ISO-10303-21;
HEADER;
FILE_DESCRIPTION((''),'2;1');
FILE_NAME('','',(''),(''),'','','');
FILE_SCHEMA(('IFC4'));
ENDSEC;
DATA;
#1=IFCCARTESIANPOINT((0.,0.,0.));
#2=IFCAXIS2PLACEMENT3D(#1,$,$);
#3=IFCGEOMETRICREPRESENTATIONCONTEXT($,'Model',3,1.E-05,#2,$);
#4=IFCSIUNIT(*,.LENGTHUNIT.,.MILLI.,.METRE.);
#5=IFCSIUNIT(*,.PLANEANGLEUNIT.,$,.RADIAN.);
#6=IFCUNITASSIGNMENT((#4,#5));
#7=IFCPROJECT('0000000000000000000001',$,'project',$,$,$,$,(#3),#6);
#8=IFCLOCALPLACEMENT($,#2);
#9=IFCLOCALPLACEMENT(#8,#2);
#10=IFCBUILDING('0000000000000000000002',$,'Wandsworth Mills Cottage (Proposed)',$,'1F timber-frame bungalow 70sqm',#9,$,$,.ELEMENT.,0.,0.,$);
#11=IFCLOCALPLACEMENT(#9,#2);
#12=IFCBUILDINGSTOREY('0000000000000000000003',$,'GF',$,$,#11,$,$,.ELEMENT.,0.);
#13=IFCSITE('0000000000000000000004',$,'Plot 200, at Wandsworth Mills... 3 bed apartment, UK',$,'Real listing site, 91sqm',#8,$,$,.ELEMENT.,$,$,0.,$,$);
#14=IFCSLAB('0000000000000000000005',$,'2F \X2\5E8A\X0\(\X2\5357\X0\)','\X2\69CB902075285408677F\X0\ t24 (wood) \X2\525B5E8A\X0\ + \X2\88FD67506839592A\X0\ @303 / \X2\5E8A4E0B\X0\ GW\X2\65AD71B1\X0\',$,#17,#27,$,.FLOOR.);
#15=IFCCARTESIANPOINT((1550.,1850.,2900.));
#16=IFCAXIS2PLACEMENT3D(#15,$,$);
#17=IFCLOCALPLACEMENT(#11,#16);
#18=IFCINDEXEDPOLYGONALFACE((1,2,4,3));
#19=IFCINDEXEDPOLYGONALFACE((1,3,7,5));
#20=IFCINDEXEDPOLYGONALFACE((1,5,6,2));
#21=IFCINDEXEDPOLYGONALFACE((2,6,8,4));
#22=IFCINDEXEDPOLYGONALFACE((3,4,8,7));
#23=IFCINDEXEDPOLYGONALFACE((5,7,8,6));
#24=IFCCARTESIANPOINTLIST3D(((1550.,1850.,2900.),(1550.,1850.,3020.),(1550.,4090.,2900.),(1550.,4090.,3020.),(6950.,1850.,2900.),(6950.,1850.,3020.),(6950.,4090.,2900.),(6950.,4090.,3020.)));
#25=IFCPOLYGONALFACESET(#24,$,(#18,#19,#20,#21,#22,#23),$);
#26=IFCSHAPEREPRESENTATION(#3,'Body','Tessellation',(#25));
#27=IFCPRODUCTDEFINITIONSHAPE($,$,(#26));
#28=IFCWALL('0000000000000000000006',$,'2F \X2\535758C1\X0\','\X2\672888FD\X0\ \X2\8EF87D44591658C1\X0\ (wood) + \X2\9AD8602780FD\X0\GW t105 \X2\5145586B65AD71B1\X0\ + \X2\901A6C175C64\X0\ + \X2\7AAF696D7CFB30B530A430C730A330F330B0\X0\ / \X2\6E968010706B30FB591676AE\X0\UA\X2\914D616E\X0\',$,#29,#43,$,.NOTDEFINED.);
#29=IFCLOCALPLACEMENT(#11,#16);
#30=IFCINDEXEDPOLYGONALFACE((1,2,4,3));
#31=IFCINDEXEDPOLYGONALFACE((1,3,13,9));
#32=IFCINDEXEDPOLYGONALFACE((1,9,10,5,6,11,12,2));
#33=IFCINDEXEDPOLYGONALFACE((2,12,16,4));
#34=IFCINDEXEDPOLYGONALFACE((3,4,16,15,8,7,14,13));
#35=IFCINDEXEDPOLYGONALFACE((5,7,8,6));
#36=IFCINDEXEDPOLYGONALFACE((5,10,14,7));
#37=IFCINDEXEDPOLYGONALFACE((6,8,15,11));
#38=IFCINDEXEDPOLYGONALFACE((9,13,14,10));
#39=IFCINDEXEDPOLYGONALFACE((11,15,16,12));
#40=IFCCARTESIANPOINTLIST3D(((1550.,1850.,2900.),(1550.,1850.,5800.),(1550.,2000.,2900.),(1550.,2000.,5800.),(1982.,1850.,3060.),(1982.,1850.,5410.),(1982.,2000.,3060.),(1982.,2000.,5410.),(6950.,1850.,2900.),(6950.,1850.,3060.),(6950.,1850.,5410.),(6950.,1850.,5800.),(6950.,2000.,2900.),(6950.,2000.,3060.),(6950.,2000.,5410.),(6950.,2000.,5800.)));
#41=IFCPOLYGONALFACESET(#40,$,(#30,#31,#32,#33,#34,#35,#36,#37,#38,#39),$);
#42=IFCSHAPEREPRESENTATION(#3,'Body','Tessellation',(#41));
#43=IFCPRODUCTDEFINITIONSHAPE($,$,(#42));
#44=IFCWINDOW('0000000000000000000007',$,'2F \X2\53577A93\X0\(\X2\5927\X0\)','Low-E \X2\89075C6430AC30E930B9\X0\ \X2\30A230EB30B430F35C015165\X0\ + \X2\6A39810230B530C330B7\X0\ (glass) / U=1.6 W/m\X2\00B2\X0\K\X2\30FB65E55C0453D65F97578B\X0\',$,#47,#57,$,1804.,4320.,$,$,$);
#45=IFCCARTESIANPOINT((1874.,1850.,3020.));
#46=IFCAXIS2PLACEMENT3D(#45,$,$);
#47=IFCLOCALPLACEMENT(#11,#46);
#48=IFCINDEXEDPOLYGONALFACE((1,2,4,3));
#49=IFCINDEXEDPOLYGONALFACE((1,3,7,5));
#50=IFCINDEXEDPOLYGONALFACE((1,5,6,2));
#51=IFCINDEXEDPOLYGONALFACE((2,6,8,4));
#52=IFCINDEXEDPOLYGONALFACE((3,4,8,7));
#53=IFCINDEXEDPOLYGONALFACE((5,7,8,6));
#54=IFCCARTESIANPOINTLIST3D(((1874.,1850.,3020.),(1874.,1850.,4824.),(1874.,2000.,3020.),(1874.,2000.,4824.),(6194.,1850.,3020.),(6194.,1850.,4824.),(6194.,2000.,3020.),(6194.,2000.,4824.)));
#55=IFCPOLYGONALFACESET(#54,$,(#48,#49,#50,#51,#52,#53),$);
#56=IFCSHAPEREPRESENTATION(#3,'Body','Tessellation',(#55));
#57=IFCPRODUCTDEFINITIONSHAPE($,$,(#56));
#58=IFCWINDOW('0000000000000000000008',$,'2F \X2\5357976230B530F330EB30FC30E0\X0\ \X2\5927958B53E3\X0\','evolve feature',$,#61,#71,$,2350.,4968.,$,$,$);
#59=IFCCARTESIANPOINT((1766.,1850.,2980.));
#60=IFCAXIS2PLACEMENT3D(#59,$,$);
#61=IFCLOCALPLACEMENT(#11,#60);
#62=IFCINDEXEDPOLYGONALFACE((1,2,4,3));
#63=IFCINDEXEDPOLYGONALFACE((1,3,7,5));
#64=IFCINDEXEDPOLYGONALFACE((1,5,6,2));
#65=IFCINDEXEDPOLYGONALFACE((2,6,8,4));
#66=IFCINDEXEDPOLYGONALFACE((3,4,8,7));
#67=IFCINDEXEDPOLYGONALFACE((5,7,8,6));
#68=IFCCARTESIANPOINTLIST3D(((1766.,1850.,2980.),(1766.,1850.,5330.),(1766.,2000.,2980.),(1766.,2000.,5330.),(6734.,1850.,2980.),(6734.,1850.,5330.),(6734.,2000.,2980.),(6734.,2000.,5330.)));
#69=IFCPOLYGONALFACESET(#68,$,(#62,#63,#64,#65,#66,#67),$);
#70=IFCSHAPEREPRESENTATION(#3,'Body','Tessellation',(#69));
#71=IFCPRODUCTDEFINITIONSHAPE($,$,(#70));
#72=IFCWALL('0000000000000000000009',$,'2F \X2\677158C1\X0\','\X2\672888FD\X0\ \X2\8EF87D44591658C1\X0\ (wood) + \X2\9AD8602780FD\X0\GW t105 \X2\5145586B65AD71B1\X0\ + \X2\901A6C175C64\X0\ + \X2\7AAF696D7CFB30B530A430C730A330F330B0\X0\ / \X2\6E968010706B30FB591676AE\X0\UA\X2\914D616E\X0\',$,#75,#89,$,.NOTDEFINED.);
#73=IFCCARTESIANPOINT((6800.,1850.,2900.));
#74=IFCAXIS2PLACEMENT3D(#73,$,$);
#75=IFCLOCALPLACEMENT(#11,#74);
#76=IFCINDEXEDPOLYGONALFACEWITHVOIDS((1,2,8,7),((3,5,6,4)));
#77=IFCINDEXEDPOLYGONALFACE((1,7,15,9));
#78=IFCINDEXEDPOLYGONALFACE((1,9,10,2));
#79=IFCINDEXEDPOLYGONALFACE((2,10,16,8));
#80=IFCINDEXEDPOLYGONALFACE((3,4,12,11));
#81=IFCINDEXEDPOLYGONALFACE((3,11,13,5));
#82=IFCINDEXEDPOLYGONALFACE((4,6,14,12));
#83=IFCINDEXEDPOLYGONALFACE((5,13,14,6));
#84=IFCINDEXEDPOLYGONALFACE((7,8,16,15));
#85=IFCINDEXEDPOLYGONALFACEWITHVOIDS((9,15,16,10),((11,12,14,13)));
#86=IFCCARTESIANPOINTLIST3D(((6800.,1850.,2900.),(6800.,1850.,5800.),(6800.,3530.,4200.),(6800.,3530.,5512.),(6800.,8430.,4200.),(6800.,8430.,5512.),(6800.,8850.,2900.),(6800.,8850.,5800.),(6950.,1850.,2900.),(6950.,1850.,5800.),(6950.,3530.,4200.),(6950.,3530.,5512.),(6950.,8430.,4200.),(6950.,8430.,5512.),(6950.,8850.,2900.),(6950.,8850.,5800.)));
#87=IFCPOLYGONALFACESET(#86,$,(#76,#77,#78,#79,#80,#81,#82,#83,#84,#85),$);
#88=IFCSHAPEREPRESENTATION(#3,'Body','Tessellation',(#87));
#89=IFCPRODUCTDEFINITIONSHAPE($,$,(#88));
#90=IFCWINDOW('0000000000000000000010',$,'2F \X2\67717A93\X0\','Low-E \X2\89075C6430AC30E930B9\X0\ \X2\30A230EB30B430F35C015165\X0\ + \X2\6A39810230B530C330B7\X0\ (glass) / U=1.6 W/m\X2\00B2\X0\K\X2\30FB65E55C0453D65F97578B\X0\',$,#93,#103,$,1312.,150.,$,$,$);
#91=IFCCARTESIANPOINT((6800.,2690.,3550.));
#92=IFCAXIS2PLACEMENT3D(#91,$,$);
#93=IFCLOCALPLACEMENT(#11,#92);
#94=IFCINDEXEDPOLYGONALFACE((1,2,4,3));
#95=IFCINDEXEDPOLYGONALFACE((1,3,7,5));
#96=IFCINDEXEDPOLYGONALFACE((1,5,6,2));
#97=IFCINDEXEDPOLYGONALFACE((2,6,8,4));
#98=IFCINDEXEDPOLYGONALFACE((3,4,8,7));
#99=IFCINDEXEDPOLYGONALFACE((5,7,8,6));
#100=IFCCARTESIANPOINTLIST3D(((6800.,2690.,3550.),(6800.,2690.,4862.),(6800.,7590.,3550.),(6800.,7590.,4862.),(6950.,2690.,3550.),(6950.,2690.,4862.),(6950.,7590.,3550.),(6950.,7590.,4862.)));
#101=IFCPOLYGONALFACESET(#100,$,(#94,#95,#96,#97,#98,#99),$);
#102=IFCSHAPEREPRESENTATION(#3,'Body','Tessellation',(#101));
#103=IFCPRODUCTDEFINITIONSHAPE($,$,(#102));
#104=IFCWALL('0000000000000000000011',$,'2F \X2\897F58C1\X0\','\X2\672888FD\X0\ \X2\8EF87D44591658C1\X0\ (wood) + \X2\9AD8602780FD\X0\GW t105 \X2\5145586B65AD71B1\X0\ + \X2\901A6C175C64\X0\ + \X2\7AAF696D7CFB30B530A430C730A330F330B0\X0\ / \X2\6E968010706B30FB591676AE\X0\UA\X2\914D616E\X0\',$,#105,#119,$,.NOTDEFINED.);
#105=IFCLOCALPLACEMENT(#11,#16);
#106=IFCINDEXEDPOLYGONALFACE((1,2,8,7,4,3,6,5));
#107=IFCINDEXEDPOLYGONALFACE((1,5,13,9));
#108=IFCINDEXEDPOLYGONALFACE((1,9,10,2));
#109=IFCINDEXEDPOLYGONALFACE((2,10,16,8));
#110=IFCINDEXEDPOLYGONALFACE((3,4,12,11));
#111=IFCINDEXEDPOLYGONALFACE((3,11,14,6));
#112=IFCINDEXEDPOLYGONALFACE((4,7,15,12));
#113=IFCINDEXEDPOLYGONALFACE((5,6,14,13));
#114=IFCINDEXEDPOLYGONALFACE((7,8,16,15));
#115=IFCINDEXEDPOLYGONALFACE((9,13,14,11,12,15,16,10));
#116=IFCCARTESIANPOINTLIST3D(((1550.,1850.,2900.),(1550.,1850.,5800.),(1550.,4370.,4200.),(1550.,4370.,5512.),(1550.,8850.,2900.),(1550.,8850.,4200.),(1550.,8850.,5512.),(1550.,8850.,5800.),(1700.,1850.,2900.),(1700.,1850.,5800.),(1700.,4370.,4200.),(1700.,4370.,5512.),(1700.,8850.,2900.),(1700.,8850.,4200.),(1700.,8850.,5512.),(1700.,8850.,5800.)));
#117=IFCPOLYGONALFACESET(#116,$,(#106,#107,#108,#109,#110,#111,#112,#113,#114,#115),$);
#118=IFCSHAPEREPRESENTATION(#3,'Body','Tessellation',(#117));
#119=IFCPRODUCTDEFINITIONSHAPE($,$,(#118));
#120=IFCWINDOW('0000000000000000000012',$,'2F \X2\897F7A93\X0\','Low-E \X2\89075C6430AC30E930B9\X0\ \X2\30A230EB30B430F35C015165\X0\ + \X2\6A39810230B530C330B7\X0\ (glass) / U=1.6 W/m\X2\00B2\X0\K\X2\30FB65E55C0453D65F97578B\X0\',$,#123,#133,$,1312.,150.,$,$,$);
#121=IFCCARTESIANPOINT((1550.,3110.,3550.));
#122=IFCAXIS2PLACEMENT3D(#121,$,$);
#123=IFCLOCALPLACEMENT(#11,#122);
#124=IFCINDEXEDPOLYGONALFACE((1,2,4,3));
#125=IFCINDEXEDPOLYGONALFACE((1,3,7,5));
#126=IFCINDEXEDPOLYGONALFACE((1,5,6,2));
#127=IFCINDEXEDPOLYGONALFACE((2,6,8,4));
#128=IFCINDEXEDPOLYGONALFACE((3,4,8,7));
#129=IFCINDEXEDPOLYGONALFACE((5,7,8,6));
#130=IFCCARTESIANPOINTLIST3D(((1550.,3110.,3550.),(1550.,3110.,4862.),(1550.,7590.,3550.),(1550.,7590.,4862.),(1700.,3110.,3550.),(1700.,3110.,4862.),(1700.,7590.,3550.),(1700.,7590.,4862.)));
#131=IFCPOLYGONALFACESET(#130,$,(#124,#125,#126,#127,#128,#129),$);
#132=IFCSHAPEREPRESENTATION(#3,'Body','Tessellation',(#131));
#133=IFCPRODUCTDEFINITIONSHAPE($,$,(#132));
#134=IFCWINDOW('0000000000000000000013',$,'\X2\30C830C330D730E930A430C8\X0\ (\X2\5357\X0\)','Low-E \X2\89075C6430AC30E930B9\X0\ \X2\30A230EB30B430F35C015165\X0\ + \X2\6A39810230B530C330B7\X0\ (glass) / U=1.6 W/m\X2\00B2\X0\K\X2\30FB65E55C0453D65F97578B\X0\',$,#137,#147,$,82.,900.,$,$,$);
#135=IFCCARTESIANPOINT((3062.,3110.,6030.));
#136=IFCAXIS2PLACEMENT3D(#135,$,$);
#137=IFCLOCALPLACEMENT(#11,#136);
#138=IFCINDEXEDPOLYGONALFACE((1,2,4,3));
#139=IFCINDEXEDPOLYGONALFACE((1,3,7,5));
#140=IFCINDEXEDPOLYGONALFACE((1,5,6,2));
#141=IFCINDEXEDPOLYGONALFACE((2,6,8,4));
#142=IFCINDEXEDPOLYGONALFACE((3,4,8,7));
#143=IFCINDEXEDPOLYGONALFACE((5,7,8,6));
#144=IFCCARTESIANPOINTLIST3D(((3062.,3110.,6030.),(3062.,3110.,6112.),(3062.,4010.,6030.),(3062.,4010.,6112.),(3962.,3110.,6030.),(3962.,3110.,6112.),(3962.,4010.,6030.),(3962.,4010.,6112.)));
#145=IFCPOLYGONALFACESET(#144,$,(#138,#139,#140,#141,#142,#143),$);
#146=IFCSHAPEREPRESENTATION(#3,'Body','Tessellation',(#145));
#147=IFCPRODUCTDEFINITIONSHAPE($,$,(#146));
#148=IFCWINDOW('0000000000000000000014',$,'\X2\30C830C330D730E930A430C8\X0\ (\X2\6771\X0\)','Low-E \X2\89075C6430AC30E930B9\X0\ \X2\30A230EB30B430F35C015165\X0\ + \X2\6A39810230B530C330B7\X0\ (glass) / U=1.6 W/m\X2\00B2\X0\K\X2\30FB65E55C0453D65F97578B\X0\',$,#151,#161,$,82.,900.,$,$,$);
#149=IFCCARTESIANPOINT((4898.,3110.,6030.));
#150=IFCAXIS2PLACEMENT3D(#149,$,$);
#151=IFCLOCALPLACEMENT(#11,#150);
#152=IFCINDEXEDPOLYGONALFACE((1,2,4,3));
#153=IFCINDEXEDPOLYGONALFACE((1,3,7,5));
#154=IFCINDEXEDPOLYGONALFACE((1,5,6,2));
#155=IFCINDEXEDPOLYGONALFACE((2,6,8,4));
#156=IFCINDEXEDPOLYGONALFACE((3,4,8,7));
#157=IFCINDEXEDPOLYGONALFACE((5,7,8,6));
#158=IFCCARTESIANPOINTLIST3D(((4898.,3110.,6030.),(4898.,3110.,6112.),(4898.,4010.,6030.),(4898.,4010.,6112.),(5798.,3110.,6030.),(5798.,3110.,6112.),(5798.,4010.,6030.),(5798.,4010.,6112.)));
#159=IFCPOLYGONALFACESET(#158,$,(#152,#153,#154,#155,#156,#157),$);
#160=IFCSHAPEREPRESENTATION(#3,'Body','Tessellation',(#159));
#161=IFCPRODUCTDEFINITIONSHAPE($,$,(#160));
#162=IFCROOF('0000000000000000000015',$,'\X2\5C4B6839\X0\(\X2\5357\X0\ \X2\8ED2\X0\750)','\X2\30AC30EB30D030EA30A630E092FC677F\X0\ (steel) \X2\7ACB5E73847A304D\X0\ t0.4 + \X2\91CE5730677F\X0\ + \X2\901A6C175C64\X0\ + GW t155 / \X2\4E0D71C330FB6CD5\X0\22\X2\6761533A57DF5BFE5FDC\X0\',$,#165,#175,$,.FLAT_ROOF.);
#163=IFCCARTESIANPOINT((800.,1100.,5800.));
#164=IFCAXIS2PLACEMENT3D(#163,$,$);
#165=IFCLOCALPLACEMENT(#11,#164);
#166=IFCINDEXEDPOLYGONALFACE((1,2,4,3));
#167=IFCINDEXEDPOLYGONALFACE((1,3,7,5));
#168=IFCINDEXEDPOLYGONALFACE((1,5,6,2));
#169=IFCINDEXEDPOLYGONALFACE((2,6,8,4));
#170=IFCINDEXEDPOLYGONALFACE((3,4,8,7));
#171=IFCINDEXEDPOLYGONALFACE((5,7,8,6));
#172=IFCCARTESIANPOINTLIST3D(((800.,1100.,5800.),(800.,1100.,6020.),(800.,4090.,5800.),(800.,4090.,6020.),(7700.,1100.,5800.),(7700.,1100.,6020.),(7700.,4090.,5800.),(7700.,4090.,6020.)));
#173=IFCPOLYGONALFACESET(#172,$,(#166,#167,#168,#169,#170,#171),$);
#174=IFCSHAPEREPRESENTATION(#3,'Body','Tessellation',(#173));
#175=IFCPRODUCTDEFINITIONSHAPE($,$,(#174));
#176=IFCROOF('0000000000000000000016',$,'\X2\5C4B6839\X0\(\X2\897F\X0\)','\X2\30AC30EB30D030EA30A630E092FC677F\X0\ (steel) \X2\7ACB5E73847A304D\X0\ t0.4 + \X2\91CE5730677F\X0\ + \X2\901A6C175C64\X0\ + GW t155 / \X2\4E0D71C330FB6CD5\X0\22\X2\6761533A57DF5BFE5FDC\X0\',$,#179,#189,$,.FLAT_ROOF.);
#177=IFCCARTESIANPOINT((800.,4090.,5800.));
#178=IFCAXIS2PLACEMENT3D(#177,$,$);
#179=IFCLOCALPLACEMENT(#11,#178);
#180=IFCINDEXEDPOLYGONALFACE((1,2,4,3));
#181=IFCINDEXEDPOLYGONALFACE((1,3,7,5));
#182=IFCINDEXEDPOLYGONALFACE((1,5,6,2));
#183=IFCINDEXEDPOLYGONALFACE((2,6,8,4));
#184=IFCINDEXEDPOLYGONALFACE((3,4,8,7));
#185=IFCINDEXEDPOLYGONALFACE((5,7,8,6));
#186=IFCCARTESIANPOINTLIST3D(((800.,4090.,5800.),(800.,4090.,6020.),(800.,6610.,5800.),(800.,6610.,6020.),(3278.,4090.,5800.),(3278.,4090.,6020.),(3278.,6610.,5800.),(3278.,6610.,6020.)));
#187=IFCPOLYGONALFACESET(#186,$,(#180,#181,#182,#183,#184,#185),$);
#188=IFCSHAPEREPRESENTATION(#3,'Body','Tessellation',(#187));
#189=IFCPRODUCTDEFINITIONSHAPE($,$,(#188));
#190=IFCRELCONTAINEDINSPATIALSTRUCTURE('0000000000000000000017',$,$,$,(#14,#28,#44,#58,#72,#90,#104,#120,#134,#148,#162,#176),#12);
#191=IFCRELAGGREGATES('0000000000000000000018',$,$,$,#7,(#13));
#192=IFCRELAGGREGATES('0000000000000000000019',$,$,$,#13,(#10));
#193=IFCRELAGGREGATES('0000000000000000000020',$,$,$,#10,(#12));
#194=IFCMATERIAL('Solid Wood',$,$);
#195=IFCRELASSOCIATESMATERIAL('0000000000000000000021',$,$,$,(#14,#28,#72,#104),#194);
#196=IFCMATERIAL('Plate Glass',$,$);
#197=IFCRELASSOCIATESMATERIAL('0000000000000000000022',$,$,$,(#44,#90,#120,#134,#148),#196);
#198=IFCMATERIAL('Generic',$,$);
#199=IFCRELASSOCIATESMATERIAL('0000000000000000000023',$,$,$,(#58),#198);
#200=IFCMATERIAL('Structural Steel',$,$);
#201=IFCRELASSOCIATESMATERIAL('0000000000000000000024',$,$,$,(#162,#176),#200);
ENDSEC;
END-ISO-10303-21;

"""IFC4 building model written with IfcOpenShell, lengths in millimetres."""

from ifc_helpers import new_model, si_unit, frame, frame_2d, origin, place, context, project, spatial, rectangle, extrude, material, element, fill, save


model = new_model("IFC4")

# Units and contexts
model_context = context("Model", 3, precision=1e-05, world=origin())
ifc_project = project(units=[si_unit("LENGTHUNIT", "METRE", prefix="MILLI"), si_unit("PLANEANGLEUNIT", "RADIAN")], contexts=[model_context])

# Site, building, storey
site_placement = place(None, origin())
site = spatial("IfcSite", under=ifc_project, at=site_placement, Name="Plot 200, at Wandsworth Mills... 3 bed apartment, UK", ObjectType="Real listing site, 91sqm", CompositionType="ELEMENT", RefElevation=0.0)
building_placement = place(site_placement, origin())
building = spatial("IfcBuilding", under=site, at=building_placement, Name="Wandsworth Mills Cottage (Proposed)", ObjectType="1F timber-frame bungalow 70sqm", CompositionType="ELEMENT", ElevationOfRefHeight=0.0, ElevationOfTerrain=0.0)
storey_placement = place(building_placement, origin())
storey = spatial("IfcBuildingStorey", under=building, at=storey_placement, Name="GF", CompositionType="ELEMENT", Elevation=0.0)

# Slab
ifc_material_1 = material(Name="Solid Wood")
slab_placement = place(storey_placement, frame((1550.0, 1850.0, 2900.0)))
element("IfcSlab", 1, at=slab_placement, inside=storey, material=ifc_material_1, Name="2F 床(南)", Description="構造用合板 t24 (wood) 剛床 + 製材根太 @303 / 床下 GW断熱", PredefinedType="FLOOR", context=model_context, shape_type="SweptSolid", body=[
    extrude(rectangle(XDim=5400.0, YDim=2240.0, at=frame_2d((2700.0, 1120.0))), frame((1550.0, 1850.0, 2900.0)), (0.0, 0.0, 1.0), 120.0),
])

# Wall, openings, windows
wall_1_placement = place(storey_placement, frame((1550.0, 1850.0, 2900.0)))
wall_1 = element("IfcWall", 2, at=wall_1_placement, inside=storey, material=ifc_material_1, Name="2F 南壁", Description="木製 軸組外壁 (wood) + 高性能GW t105 充填断熱 + 通気層 + 窯業系サイディング / 準耐火・外皮UA配慮", PredefinedType="NOTDEFINED", context=model_context, shape_type="SweptSolid", body=[
    extrude(rectangle(XDim=5400.0, YDim=150.0, at=frame_2d((2700.0, 75.0))), frame((1550.0, 1850.0, 2900.0)), (0.0, 0.0, 1.0), 2900.0),
])
opening_1_placement = place(storey_placement, frame((1874.0, 1850.0, 3020.0)))
opening_1 = element("IfcOpeningElement", 3, at=opening_1_placement, cuts=wall_1, PredefinedType="NOTDEFINED", context=model_context, shape_type="SweptSolid", body=[
    extrude(rectangle(XDim=4320.0, YDim=150.0, at=frame_2d((2160.0, 75.0))), frame((1874.0, 1850.0, 3020.0)), (0.0, 0.0, 1.0), 1804.0),
])
opening_2_placement = place(storey_placement, frame((1766.0, 1850.0, 2980.0)))
opening_2 = element("IfcOpeningElement", 4, at=opening_2_placement, cuts=wall_1, PredefinedType="NOTDEFINED", context=model_context, shape_type="SweptSolid", body=[
    extrude(rectangle(XDim=4968.0, YDim=150.0, at=frame_2d((2484.0, 75.0))), frame((1766.0, 1850.0, 2980.0)), (0.0, 0.0, 1.0), 2350.0),
])
ifc_material_2 = material(Name="Plate Glass")
window_1_placement = place(storey_placement, frame((1874.0, 1850.0, 3020.0)))
window_1 = element("IfcWindow", 5, at=window_1_placement, inside=storey, material=ifc_material_2, Name="2F 南窓(大)", Description="Low-E 複層ガラス アルゴン封入 + 樹脂サッシ (glass) / U=1.6 W/m²K・日射取得型", OverallHeight=1804.0, OverallWidth=4320.0, context=model_context, shape_type="SweptSolid", body=[
    extrude(rectangle(XDim=4320.0, YDim=150.0, at=frame_2d((2160.0, 75.0))), frame((1874.0, 1850.0, 3020.0)), (0.0, 0.0, 1.0), 1804.0),
])
fill(opening_1, window_1)
ifc_material_3 = material(Name="Generic")
window_2_placement = place(storey_placement, frame((1766.0, 1850.0, 2980.0)))
window_2 = element("IfcWindow", 6, at=window_2_placement, inside=storey, material=ifc_material_3, Name="2F 南面サンルーム 大開口", Description="evolve feature", OverallHeight=2350.0, OverallWidth=4968.0, context=model_context, shape_type="SweptSolid", body=[
    extrude(rectangle(XDim=4968.0, YDim=150.0, at=frame_2d((2484.0, 75.0))), frame((1766.0, 1850.0, 2980.0)), (0.0, 0.0, 1.0), 2350.0),
])
fill(opening_2, window_2)

# Walls, openings, windows
wall_2_placement = place(storey_placement, frame((6800.0, 1850.0, 2900.0)))
wall_2 = element("IfcWall", 7, at=wall_2_placement, inside=storey, material=ifc_material_1, Name="2F 東壁", Description="木製 軸組外壁 (wood) + 高性能GW t105 充填断熱 + 通気層 + 窯業系サイディング / 準耐火・外皮UA配慮", PredefinedType="NOTDEFINED", context=model_context, shape_type="SweptSolid", body=[
    extrude(rectangle(XDim=150.0, YDim=7000.0, at=frame_2d((75.0, 3500.0))), frame((6800.0, 1850.0, 2900.0)), (0.0, 0.0, 1.0), 2900.0),
])
opening_3_placement = place(storey_placement, frame((6800.0, 2690.0, 3550.0)))
opening_3 = element("IfcOpeningElement", 8, at=opening_3_placement, cuts=wall_2, PredefinedType="NOTDEFINED", context=model_context, shape_type="SweptSolid", body=[
    extrude(rectangle(XDim=150.0, YDim=4900.0, at=frame_2d((75.0, 2450.0))), frame((6800.0, 2690.0, 3550.0)), (0.0, 0.0, 1.0), 1312.0),
])
window_3_placement = place(storey_placement, frame((6800.0, 2690.0, 3550.0)))
window_3 = element("IfcWindow", 9, at=window_3_placement, inside=storey, material=ifc_material_2, Name="2F 東窓", Description="Low-E 複層ガラス アルゴン封入 + 樹脂サッシ (glass) / U=1.6 W/m²K・日射取得型", OverallHeight=1312.0, OverallWidth=150.0, context=model_context, shape_type="SweptSolid", body=[
    extrude(rectangle(XDim=150.0, YDim=4900.0, at=frame_2d((75.0, 2450.0))), frame((6800.0, 2690.0, 3550.0)), (0.0, 0.0, 1.0), 1312.0),
])
fill(opening_3, window_3)
wall_3_placement = place(storey_placement, frame((1550.0, 1850.0, 2900.0)))
wall_3 = element("IfcWall", 10, at=wall_3_placement, inside=storey, material=ifc_material_1, Name="2F 西壁", Description="木製 軸組外壁 (wood) + 高性能GW t105 充填断熱 + 通気層 + 窯業系サイディング / 準耐火・外皮UA配慮", PredefinedType="NOTDEFINED", context=model_context, shape_type="SweptSolid", body=[
    extrude(rectangle(XDim=150.0, YDim=7000.0, at=frame_2d((75.0, 3500.0))), frame((1550.0, 1850.0, 2900.0)), (0.0, 0.0, 1.0), 2900.0),
])
opening_4_placement = place(storey_placement, frame((1550.0, 3110.0, 3550.0)))
opening_4 = element("IfcOpeningElement", 11, at=opening_4_placement, cuts=wall_3, PredefinedType="NOTDEFINED", context=model_context, shape_type="SweptSolid", body=[
    extrude(rectangle(XDim=150.0, YDim=4480.0, at=frame_2d((75.0, 2240.0))), frame((1550.0, 3110.0, 3550.0)), (0.0, 0.0, 1.0), 1312.0),
])
window_4_placement = place(storey_placement, frame((1550.0, 3110.0, 3550.0)))
window_4 = element("IfcWindow", 12, at=window_4_placement, inside=storey, material=ifc_material_2, Name="2F 西窓", Description="Low-E 複層ガラス アルゴン封入 + 樹脂サッシ (glass) / U=1.6 W/m²K・日射取得型", OverallHeight=1312.0, OverallWidth=150.0, context=model_context, shape_type="SweptSolid", body=[
    extrude(rectangle(XDim=150.0, YDim=4480.0, at=frame_2d((75.0, 2240.0))), frame((1550.0, 3110.0, 3550.0)), (0.0, 0.0, 1.0), 1312.0),
])
fill(opening_4, window_4)

# Windows
window_5_placement = place(storey_placement, frame((3062.0, 3110.0, 6030.0)))
element("IfcWindow", 13, at=window_5_placement, inside=storey, material=ifc_material_2, Name="トップライト (南)", Description="Low-E 複層ガラス アルゴン封入 + 樹脂サッシ (glass) / U=1.6 W/m²K・日射取得型", OverallHeight=82.0, OverallWidth=900.0, context=model_context, shape_type="SweptSolid", body=[
    extrude(rectangle(XDim=900.0, YDim=900.0, at=frame_2d((450.0, 450.0))), frame((3062.0, 3110.0, 6030.0)), (0.0, 0.0, 1.0), 82.0),
])
window_6_placement = place(storey_placement, frame((4898.0, 3110.0, 6030.0)))
element("IfcWindow", 14, at=window_6_placement, inside=storey, material=ifc_material_2, Name="トップライト (東)", Description="Low-E 複層ガラス アルゴン封入 + 樹脂サッシ (glass) / U=1.6 W/m²K・日射取得型", OverallHeight=82.0, OverallWidth=900.0, context=model_context, shape_type="SweptSolid", body=[
    extrude(rectangle(XDim=900.0, YDim=900.0, at=frame_2d((450.0, 450.0))), frame((4898.0, 3110.0, 6030.0)), (0.0, 0.0, 1.0), 82.0),
])

# Roofs
ifc_material_4 = material(Name="Structural Steel")
roof_1_placement = place(storey_placement, frame((800.0, 1100.0, 5800.0)))
element("IfcRoof", 15, at=roof_1_placement, inside=storey, material=ifc_material_4, Name="屋根(南 軒750)", Description="ガルバリウム鋼板 (steel) 立平葺き t0.4 + 野地板 + 通気層 + GW t155 / 不燃・法22条区域対応", PredefinedType="FLAT_ROOF", context=model_context, shape_type="SweptSolid", body=[
    extrude(rectangle(XDim=6900.0, YDim=2990.0, at=frame_2d((3450.0, 1495.0))), frame((800.0, 1100.0, 5800.0)), (0.0, 0.0, 1.0), 220.0),
])
roof_2_placement = place(storey_placement, frame((800.0, 4090.0, 5800.0)))
element("IfcRoof", 16, at=roof_2_placement, inside=storey, material=ifc_material_4, Name="屋根(西)", Description="ガルバリウム鋼板 (steel) 立平葺き t0.4 + 野地板 + 通気層 + GW t155 / 不燃・法22条区域対応", PredefinedType="FLAT_ROOF", context=model_context, shape_type="SweptSolid", body=[
    extrude(rectangle(XDim=2478.0, YDim=2520.0, at=frame_2d((1239.0, 1260.0))), frame((800.0, 4090.0, 5800.0)), (0.0, 0.0, 1.0), 220.0),
])

save(model, "model.ifc")
